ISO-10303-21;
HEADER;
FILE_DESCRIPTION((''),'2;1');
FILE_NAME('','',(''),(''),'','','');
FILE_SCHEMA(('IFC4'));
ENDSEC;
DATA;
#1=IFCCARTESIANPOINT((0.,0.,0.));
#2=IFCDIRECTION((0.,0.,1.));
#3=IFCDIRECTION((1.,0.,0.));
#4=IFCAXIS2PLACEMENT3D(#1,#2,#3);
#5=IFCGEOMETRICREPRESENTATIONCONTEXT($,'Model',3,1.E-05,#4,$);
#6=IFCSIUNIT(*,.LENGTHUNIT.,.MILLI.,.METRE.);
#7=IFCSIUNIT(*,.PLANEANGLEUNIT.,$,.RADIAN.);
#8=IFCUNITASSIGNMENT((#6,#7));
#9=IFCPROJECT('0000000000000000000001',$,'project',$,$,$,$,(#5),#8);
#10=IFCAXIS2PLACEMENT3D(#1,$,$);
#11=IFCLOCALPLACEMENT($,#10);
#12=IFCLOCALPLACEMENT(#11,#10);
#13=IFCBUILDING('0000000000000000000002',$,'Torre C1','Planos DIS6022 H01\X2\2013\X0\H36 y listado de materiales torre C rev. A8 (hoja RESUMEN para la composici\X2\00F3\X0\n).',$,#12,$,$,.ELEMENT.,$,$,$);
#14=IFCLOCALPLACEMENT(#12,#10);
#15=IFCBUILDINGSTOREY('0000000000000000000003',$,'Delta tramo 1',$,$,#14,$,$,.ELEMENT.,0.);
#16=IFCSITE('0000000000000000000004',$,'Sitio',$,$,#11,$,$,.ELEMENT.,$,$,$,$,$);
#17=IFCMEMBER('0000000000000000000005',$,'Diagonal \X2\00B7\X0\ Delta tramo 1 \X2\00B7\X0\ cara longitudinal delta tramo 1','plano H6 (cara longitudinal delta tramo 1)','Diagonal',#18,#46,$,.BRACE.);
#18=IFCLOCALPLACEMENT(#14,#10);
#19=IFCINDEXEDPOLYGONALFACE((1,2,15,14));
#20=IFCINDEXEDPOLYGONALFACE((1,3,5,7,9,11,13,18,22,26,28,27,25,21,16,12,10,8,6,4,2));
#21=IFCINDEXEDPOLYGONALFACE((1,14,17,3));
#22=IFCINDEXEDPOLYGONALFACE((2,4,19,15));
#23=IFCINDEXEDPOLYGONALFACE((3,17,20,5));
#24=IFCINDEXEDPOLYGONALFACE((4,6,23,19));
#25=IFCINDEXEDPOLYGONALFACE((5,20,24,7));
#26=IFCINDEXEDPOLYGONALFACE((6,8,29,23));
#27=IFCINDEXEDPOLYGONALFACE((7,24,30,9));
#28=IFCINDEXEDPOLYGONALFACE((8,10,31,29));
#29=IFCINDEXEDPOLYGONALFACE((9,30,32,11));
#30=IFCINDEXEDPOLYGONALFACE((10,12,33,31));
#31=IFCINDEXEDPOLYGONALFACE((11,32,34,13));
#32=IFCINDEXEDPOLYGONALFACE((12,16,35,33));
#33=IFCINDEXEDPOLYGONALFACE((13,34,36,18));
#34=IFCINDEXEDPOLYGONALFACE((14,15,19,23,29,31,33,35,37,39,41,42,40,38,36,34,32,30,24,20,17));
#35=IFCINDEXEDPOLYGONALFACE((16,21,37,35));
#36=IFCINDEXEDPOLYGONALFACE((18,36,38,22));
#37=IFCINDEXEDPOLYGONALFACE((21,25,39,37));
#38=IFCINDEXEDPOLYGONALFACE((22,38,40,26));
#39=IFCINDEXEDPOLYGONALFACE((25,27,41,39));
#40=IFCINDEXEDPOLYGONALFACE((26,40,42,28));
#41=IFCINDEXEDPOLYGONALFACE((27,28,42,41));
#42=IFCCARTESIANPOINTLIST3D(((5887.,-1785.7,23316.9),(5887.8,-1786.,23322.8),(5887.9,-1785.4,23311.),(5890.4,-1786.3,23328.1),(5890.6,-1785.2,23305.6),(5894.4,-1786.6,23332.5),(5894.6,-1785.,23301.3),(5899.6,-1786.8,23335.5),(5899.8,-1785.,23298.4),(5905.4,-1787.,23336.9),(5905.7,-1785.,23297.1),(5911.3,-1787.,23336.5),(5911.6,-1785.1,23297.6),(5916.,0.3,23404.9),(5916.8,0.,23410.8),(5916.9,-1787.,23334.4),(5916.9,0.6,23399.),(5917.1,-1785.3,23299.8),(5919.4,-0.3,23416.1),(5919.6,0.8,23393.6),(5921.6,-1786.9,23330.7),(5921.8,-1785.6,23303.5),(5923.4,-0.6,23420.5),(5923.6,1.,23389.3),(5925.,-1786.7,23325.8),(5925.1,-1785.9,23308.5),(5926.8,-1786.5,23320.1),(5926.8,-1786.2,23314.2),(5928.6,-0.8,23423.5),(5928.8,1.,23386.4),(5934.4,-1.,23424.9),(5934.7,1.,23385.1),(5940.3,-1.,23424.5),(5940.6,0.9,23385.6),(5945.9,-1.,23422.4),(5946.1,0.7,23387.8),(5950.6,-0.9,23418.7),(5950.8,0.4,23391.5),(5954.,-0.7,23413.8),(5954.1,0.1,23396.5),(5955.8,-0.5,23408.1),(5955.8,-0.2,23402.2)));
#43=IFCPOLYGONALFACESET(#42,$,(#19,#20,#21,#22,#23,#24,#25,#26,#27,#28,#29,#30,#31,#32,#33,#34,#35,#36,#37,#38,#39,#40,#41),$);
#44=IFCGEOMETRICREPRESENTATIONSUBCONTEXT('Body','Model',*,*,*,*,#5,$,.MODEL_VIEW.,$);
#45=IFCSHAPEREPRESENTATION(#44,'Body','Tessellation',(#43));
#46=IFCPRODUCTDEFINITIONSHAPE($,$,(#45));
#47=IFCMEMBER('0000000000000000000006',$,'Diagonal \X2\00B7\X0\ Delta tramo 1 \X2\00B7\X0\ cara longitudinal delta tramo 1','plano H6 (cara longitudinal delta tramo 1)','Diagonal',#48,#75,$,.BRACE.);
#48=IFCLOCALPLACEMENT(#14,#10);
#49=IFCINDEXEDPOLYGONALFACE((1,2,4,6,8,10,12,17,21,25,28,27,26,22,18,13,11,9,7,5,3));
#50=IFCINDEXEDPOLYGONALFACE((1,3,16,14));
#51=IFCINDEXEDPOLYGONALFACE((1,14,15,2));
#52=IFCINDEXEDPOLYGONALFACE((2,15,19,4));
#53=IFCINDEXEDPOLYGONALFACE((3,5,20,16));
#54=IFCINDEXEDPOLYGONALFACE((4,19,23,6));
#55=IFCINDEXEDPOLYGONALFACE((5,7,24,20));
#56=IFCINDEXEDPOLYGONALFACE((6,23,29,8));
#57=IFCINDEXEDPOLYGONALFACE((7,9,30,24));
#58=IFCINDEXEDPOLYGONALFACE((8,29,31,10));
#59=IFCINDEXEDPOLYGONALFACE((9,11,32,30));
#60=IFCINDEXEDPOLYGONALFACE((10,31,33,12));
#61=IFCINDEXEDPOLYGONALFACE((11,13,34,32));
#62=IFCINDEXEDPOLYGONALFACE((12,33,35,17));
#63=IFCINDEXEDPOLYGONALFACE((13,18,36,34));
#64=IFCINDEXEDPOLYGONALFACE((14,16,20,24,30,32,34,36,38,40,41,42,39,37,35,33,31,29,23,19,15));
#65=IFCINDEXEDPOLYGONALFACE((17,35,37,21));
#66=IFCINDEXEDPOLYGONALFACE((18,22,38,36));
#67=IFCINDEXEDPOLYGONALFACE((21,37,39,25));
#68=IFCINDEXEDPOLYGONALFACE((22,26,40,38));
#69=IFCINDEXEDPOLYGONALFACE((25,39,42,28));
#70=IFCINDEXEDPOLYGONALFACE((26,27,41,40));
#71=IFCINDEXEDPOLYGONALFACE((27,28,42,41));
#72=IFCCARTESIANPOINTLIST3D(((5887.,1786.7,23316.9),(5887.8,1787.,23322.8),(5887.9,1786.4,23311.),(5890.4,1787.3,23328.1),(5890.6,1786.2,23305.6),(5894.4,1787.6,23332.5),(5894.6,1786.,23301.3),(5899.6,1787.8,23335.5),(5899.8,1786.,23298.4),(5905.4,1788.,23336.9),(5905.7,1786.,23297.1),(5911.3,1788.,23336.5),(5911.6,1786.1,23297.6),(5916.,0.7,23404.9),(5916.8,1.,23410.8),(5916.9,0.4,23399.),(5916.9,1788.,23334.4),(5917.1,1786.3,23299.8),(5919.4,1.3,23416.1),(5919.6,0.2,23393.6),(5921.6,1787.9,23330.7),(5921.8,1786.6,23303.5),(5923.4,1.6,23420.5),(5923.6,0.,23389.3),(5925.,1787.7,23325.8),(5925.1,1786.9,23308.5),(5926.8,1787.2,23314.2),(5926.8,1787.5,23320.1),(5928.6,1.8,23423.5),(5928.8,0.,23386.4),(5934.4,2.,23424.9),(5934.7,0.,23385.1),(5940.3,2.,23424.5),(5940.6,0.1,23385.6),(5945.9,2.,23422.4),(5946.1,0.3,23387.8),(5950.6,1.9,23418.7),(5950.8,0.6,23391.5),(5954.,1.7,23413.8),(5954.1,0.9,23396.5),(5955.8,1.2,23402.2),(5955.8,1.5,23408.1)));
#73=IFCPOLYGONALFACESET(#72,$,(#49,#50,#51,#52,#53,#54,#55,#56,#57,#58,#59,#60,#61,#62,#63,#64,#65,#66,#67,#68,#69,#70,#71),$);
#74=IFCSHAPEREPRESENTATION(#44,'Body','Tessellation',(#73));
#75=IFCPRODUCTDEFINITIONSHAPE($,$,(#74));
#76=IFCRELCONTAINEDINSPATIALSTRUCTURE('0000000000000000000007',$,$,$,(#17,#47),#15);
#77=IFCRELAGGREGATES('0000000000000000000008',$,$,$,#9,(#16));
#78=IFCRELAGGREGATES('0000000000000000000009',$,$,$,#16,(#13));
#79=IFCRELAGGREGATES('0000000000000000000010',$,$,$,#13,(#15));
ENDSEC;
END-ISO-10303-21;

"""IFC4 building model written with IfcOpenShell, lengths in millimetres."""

from ifc_helpers import new_model, si_unit, frame, origin, origin_with_axes, place, context, subcontext, project, spatial, circle, extrude, element, save


model = new_model("IFC4")

# Units and contexts
model_context = context("Model", 3, precision=1e-05, world=origin_with_axes())
body_context = subcontext(model_context, "Body", "Model", "MODEL_VIEW")
ifc_project = project(units=[si_unit("LENGTHUNIT", "METRE", prefix="MILLI"), si_unit("PLANEANGLEUNIT", "RADIAN")], contexts=[model_context])

# Site, building, storey
site_placement = place(None, origin())
site = spatial("IfcSite", under=ifc_project, at=site_placement, Name="Sitio", CompositionType="ELEMENT")
building_placement = place(site_placement, origin())
building = spatial("IfcBuilding", under=site, at=building_placement, Name="Torre C1", Description="Planos DIS6022 H01–H36 y listado de materiales torre C rev. A8 (hoja RESUMEN para la composición).", CompositionType="ELEMENT")
storey_placement = place(building_placement, origin())
storey = spatial("IfcBuildingStorey", under=building, at=storey_placement, Name="Delta tramo 1", CompositionType="ELEMENT", Elevation=0.0)

# Members
for number, where, z_axis, x_axis, name in (
    (1, (5936.0, 0.0, 23405.0), (-0.016216, -0.998657, -0.049206), (-0.999841, 0.01656, -0.006597), "Diagonal · Delta tramo 1 · cara longitudinal delta tramo 1"),
    (2, (5936.0, 1.0, 23405.0), (-0.016216, 0.998657, -0.049206), (-0.999841, -0.01656, -0.006606), "Diagonal · Delta tramo 1 · cara longitudinal delta tramo 1"),
):
    element("IfcMember", number, at=place(storey_placement, frame(where, z_axis=z_axis, x_axis=x_axis)), inside=storey, Name=name, Description="plano H6 (cara longitudinal delta tramo 1)", ObjectType="Diagonal", PredefinedType="BRACE", context=body_context, shape_type="SweptSolid", body=[
        extrude(circle(Radius=20.0), None, (0.0, 0.0, 1.0), 1788.4),
    ])

save(model, "model.ifc")
